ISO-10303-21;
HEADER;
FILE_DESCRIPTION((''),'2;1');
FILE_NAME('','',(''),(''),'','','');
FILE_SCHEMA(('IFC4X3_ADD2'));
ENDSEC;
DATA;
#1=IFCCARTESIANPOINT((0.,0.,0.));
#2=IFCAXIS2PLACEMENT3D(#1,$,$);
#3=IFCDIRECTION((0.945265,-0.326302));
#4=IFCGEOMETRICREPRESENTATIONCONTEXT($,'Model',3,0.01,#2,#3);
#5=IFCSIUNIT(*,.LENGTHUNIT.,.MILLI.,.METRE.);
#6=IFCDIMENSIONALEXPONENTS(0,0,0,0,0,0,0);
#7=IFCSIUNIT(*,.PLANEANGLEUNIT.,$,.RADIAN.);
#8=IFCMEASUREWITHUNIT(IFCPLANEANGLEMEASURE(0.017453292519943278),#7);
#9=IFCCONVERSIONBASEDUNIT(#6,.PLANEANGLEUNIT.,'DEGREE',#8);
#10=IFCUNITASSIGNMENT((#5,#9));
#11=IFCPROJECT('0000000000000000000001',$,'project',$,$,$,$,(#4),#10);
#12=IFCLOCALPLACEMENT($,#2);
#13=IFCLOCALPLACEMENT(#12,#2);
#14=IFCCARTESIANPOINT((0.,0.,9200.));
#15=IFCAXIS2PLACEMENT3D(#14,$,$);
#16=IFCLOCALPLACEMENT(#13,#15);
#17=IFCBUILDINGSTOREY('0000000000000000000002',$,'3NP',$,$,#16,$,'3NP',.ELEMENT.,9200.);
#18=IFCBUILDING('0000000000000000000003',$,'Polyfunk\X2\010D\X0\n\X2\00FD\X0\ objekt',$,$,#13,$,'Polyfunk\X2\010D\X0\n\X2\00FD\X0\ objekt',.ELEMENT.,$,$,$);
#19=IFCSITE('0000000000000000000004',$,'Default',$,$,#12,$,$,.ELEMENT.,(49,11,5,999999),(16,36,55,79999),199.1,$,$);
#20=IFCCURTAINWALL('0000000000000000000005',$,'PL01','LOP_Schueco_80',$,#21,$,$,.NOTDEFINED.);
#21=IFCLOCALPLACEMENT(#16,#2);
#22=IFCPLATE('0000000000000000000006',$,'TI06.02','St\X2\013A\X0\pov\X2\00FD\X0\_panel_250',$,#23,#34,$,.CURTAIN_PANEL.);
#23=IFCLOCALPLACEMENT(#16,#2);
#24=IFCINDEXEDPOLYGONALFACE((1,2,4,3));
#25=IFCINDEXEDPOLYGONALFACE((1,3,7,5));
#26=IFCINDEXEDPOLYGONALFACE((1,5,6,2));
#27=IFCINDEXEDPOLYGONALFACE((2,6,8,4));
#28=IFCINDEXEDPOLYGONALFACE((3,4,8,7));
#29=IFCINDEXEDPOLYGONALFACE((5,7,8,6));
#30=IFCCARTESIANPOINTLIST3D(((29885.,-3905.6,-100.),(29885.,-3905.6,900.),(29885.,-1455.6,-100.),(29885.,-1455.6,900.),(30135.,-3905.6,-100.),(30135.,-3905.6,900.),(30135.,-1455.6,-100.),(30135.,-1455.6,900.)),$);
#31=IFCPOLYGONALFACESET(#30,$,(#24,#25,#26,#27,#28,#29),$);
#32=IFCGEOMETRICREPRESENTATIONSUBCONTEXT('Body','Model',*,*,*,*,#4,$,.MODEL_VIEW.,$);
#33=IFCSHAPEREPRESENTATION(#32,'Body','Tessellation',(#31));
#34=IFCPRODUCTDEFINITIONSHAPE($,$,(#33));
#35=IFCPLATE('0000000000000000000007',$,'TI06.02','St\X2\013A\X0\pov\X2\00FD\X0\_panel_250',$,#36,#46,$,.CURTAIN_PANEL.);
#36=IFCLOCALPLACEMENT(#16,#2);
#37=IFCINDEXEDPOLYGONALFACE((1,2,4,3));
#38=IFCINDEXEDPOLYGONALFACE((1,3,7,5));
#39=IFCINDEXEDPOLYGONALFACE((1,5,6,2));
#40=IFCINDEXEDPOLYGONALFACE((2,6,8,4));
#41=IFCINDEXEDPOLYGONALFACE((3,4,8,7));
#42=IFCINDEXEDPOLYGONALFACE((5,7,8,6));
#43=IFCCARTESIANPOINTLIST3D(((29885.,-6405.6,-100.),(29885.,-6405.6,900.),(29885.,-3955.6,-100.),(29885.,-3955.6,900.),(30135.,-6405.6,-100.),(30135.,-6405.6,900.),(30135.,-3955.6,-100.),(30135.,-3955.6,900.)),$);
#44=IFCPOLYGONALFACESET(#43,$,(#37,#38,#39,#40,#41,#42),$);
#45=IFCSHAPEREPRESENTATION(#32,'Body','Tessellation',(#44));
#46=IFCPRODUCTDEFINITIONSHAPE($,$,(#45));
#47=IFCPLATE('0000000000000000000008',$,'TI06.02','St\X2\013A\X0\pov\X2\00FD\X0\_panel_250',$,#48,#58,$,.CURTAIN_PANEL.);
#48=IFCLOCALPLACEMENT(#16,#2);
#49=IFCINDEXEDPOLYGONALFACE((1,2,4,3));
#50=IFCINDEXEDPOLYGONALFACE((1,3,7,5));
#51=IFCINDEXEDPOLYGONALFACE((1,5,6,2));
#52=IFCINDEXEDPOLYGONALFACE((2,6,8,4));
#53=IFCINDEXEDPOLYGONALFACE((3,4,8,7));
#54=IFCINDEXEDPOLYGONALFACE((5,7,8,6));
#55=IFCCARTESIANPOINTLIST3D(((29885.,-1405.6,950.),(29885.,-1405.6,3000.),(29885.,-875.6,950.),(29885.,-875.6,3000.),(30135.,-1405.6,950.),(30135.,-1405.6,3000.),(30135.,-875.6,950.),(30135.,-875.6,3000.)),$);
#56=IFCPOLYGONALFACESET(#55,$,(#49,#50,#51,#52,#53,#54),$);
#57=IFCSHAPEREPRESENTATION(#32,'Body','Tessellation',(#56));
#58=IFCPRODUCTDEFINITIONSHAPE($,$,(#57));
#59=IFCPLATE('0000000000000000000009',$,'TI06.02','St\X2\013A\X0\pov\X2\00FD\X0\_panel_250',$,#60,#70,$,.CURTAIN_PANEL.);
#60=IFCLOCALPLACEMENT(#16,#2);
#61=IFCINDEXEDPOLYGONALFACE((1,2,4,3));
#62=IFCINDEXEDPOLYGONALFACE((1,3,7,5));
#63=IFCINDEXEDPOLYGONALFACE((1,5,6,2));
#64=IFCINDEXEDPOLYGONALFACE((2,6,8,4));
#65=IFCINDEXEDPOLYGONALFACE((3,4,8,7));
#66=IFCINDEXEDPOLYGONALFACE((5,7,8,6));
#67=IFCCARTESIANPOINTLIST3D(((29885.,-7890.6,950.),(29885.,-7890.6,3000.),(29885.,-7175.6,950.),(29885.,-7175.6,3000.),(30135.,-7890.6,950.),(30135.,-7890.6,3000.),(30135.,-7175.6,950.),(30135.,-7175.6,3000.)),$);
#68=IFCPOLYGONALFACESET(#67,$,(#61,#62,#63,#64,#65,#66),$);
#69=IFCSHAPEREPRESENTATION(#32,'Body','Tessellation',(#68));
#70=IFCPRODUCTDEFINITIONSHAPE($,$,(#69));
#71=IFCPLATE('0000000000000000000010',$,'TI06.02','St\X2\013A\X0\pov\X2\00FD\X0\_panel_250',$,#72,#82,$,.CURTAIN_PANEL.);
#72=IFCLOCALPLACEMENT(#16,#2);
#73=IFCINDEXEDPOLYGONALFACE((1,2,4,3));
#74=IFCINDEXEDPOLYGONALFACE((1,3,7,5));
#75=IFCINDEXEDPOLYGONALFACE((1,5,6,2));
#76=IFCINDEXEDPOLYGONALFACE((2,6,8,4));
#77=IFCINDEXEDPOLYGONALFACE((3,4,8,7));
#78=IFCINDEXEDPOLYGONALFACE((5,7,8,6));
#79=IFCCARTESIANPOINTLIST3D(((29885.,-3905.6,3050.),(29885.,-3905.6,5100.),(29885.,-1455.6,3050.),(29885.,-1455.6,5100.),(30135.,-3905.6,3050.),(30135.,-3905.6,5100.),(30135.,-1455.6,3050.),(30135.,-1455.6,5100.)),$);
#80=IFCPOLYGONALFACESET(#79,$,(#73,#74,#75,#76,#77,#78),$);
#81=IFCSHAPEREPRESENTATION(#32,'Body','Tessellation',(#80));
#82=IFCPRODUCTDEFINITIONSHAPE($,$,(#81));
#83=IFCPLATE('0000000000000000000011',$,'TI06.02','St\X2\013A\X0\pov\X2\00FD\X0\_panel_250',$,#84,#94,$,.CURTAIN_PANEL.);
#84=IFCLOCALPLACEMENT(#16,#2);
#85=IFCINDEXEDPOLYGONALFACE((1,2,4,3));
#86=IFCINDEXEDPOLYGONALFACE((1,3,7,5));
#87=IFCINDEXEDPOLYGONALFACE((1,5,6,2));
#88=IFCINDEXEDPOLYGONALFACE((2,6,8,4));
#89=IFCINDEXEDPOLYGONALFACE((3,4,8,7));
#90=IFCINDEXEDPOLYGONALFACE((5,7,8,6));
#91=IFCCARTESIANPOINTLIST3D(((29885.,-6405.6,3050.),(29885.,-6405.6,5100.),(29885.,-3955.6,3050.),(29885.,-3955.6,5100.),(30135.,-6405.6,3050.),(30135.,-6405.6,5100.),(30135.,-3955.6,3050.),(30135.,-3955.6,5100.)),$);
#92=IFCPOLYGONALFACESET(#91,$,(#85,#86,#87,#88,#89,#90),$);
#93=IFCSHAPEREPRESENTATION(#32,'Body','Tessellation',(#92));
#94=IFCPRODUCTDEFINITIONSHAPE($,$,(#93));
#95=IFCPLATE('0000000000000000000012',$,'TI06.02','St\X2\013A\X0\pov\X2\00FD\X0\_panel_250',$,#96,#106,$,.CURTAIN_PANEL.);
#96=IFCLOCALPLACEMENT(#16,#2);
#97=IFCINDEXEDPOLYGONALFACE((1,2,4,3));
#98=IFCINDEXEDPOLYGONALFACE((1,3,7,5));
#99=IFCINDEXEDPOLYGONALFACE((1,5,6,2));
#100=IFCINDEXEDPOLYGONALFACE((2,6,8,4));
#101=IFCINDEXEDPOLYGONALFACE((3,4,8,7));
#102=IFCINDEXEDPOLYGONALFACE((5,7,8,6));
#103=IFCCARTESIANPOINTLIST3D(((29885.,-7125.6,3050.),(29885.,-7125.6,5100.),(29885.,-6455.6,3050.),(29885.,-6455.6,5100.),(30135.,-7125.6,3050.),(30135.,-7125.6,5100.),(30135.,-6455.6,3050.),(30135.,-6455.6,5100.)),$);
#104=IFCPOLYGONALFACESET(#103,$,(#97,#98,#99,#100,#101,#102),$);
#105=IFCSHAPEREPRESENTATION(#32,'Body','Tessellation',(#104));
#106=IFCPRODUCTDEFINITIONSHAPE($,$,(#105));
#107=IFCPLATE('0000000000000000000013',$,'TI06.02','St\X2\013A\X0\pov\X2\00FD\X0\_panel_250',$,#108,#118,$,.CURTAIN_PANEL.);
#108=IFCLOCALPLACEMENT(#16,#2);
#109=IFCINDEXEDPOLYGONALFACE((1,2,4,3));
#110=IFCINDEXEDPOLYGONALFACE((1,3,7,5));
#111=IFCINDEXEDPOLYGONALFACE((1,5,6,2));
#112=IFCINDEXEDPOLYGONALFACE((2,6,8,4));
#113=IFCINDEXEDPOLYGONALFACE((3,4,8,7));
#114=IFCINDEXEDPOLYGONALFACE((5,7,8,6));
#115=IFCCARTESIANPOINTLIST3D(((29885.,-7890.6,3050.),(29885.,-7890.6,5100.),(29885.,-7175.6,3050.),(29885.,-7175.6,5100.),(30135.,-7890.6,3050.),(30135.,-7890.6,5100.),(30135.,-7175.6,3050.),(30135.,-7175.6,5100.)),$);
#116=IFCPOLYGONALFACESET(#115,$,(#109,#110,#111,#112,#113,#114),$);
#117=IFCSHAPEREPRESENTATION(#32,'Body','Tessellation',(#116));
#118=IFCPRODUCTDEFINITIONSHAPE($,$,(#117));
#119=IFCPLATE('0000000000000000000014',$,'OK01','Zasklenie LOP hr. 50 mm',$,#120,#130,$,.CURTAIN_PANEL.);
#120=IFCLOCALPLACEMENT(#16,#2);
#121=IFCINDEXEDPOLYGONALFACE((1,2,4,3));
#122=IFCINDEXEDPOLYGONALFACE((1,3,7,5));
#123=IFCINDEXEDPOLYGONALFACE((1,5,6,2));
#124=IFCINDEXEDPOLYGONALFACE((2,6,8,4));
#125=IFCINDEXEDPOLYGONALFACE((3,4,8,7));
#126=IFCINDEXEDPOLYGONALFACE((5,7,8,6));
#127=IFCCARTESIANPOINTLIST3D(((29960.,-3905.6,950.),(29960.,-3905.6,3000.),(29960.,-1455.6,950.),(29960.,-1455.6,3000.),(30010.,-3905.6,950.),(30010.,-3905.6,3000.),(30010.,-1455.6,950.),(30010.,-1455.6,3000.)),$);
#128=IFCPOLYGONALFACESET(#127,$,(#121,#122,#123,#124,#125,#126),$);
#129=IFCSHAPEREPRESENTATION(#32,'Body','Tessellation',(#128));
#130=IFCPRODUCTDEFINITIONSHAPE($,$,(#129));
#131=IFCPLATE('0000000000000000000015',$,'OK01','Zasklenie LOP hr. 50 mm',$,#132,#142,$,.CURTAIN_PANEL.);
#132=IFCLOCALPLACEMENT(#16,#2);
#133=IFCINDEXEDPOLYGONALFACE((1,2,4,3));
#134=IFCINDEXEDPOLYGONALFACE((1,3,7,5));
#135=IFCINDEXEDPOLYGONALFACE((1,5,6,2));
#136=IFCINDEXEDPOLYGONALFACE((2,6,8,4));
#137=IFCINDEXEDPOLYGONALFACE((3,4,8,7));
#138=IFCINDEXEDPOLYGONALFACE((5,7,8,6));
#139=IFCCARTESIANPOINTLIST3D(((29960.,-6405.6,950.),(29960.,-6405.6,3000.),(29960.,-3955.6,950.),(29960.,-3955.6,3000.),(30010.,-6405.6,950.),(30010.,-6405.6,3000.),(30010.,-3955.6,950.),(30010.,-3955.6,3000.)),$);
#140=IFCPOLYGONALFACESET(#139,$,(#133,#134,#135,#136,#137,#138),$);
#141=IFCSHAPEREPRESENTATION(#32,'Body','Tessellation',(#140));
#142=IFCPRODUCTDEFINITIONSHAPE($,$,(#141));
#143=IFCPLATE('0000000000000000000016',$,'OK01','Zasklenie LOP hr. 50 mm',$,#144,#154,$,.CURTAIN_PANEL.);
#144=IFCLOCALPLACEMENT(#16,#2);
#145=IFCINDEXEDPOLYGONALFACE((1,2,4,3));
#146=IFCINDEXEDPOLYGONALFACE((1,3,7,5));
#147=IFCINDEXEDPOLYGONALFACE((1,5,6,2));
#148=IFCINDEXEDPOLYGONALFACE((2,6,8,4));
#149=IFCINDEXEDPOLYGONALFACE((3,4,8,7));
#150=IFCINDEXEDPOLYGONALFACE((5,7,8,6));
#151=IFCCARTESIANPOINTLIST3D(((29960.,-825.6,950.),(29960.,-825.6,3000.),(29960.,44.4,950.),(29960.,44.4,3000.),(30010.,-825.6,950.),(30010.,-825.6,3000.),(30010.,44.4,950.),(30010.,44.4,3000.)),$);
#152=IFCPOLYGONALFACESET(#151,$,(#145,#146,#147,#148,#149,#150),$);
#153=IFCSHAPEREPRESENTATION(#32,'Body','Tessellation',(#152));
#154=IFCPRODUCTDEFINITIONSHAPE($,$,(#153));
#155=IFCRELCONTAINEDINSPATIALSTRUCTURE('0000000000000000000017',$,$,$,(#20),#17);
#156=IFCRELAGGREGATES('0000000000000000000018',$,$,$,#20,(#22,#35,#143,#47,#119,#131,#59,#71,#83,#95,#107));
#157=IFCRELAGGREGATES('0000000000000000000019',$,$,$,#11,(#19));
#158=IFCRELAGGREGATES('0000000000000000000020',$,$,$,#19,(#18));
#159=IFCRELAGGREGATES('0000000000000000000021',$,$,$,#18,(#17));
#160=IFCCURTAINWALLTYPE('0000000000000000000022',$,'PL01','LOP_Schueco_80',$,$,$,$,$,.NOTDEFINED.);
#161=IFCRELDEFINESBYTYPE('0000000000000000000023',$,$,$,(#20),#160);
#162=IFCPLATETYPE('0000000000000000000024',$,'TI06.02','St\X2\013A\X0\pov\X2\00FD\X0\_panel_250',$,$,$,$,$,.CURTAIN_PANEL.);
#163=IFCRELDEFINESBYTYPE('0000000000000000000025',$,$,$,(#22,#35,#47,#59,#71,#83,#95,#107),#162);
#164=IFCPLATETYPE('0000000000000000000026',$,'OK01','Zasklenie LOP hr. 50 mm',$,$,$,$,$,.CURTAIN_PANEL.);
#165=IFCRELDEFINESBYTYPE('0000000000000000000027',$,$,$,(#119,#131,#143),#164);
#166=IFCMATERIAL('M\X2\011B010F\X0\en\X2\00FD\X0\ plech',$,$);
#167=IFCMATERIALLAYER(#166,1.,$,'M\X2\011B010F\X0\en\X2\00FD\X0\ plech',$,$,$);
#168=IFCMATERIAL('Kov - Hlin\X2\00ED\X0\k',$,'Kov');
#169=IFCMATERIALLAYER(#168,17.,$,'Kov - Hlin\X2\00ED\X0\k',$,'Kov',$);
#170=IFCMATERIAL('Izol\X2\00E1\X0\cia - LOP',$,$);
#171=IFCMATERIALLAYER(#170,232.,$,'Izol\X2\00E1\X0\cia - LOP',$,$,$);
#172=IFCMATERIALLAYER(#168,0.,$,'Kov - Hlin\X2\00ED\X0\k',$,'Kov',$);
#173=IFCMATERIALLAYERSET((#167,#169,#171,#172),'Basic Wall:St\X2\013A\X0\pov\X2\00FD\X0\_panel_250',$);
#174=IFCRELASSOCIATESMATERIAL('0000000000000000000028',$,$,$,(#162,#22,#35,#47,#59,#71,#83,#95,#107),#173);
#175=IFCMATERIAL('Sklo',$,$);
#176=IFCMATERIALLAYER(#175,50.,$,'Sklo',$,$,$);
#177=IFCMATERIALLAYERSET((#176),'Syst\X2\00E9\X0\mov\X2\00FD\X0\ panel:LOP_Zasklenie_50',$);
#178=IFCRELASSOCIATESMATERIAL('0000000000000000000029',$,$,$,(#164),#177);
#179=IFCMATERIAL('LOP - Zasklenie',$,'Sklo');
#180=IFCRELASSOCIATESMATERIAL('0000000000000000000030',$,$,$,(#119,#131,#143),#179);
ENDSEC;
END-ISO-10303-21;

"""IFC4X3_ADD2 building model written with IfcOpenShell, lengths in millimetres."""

from ifc_helpers import new_model, entity, si_unit, converted_unit, direction, frame, frame_2d, origin, origin_2d_with_axis, place, context, subcontext, project, spatial, rectangle, extrude, source, transform, mapped, material, layer, layer_set, layer_usage, type_object, type_shapes, element, aggregate, save


model = new_model("IFC4X3_ADD2")

# Units and contexts
model_context = context("Model", 3, precision=0.01, world=origin(), true_north=direction((0.945265, -0.326302)))
body_context = subcontext(model_context, "Body", "Model", "MODEL_VIEW")
ifc_project = project(units=[si_unit("LENGTHUNIT", "METRE", prefix="MILLI"), converted_unit("PLANEANGLEUNIT", "DEGREE", entity("IfcPlaneAngleMeasure", 0.017453292519943278), si_unit("PLANEANGLEUNIT", "RADIAN"), dimensions=[0, 0, 0, 0, 0, 0, 0])], contexts=[model_context])

# Site, building, storey
site_placement = place(None, origin())
site = spatial("IfcSite", under=ifc_project, at=site_placement, Name="Default", CompositionType="ELEMENT", RefLatitude=(49, 11, 5, 999999), RefLongitude=(16, 36, 55, 79999), RefElevation=199.1)
building_placement = place(site_placement, origin())
building = spatial("IfcBuilding", under=site, at=building_placement, Name="Polyfunkčný objekt", LongName="Polyfunkčný objekt", CompositionType="ELEMENT")
storey_placement = place(building_placement, frame((0.0, 0.0, 9200.0)))
storey = spatial("IfcBuildingStorey", under=building, at=storey_placement, Name="3NP", LongName="3NP", CompositionType="ELEMENT", Elevation=9200.0)

# Curtain wall, plates
curtain_wall_type = type_object("IfcCurtainWallType", Name="PL01", Description="LOP_Schueco_80", PredefinedType="NOTDEFINED")
curtain_wall_placement = place(storey_placement, frame((0.0, 0.0, -9200.0)))
curtain_wall = element("IfcCurtainWall", 1, at=curtain_wall_placement, inside=storey, type_object=curtain_wall_type, Name="PL01", Description="LOP_Schueco_80", PredefinedType="NOTDEFINED")
ifc_material_1 = material(Name="Měďený plech")
ifc_layer_1 = layer(ifc_material_1, 1.0, Name="Měďený plech")
ifc_material_2 = material(Name="Kov - Hliník", Category="Kov")
ifc_layer_2 = layer(ifc_material_2, 17.0, Name="Kov - Hliník", Category="Kov")
ifc_material_3 = material(Name="Izolácia - LOP")
ifc_layer_3 = layer(ifc_material_3, 232.0, Name="Izolácia - LOP")
ifc_layer_4 = layer(ifc_material_2, 0.0, Name="Kov - Hliník", Category="Kov")
ifc_layer_set_1 = layer_set([ifc_layer_1, ifc_layer_2, ifc_layer_3, ifc_layer_4], Name="Basic Wall:Stĺpový_panel_250")
ifc_layer_usage_1 = layer_usage(ifc_layer_set_1, "AXIS2", "POSITIVE", -125.0)
plate_type_1 = type_object("IfcPlateType", Name="TI06.02", Description="Stĺpový_panel_250", PredefinedType="CURTAIN_PANEL", material=ifc_layer_set_1)
plate_1_placement = place(storey_placement, frame((30010.0, -1455.6, -100.0), z_axis=(0.0, 0.0, 1.0), x_axis=(0.0, -1.0, 0.0)))
plate_1 = element("IfcPlate", 2, at=plate_1_placement, type_object=plate_type_1, material=ifc_layer_usage_1, Name="TI06.02", Description="Stĺpový_panel_250", PredefinedType="CURTAIN_PANEL", context=body_context, shape_type="SweptSolid", body=[
    extrude(rectangle(XDim=250.0, YDim=2450.0, at=origin_2d_with_axis()), frame((1225.0, 0.0, 0.0), z_axis=(0.0, 0.0, 1.0), x_axis=(0.0, 1.0, 0.0)), (0.0, 0.0, 1.0), 1000.0),
])
ifc_layer_usage_2 = layer_usage(ifc_layer_set_1, "AXIS2", "POSITIVE", -125.0)
plate_2_placement = place(storey_placement, frame((30010.0, -3955.6, -100.0), z_axis=(0.0, 0.0, 1.0), x_axis=(0.0, -1.0, 0.0)))
plate_2 = element("IfcPlate", 3, at=plate_2_placement, type_object=plate_type_1, material=ifc_layer_usage_2, Name="TI06.02", Description="Stĺpový_panel_250", PredefinedType="CURTAIN_PANEL", context=body_context, shape_type="SweptSolid", body=[
    extrude(rectangle(XDim=250.0, YDim=2450.0, at=frame_2d((0.0, 0.0), x_axis=(1.0, 0.0))), frame((1225.0, 0.0, 0.0), z_axis=(0.0, 0.0, 1.0), x_axis=(0.0, 1.0, 0.0)), (0.0, 0.0, 1.0), 1000.0),
])
ifc_layer_usage_3 = layer_usage(ifc_layer_set_1, "AXIS2", "POSITIVE", -125.0)
plate_3_placement = place(storey_placement, frame((30010.0, -875.6, 950.0), z_axis=(0.0, 0.0, 1.0), x_axis=(0.0, -1.0, 0.0)))
plate_3 = element("IfcPlate", 4, at=plate_3_placement, type_object=plate_type_1, material=ifc_layer_usage_3, Name="TI06.02", Description="Stĺpový_panel_250", PredefinedType="CURTAIN_PANEL", context=body_context, shape_type="SweptSolid", body=[
    extrude(rectangle(XDim=250.0, YDim=530.0, at=frame_2d((0.0, 0.0), x_axis=(1.0, 0.0))), frame((265.0, 0.0, 0.0), z_axis=(0.0, 0.0, 1.0), x_axis=(0.0, 1.0, 0.0)), (0.0, 0.0, 1.0), 2050.0),
])
ifc_layer_usage_4 = layer_usage(ifc_layer_set_1, "AXIS2", "POSITIVE", -125.0)
plate_4_placement = place(storey_placement, frame((30010.0, -7175.6, 950.0), z_axis=(0.0, 0.0, 1.0), x_axis=(0.0, -1.0, 0.0)))
plate_4 = element("IfcPlate", 5, at=plate_4_placement, type_object=plate_type_1, material=ifc_layer_usage_4, Name="TI06.02", Description="Stĺpový_panel_250", PredefinedType="CURTAIN_PANEL", context=body_context, shape_type="SweptSolid", body=[
    extrude(rectangle(XDim=250.0, YDim=715.0, at=frame_2d((0.0, 0.0), x_axis=(1.0, 0.0))), frame((357.5, 0.0, 0.0), z_axis=(0.0, 0.0, 1.0), x_axis=(0.0, 1.0, 0.0)), (0.0, 0.0, 1.0), 2050.0),
])
ifc_layer_usage_5 = layer_usage(ifc_layer_set_1, "AXIS2", "POSITIVE", -125.0)
plate_5_placement = place(storey_placement, frame((30010.0, -1455.6, 3050.0), z_axis=(0.0, 0.0, 1.0), x_axis=(0.0, -1.0, 0.0)))
plate_5 = element("IfcPlate", 6, at=plate_5_placement, type_object=plate_type_1, material=ifc_layer_usage_5, Name="TI06.02", Description="Stĺpový_panel_250", PredefinedType="CURTAIN_PANEL", context=body_context, shape_type="SweptSolid", body=[
    extrude(rectangle(XDim=250.0, YDim=2450.0, at=origin_2d_with_axis()), frame((1225.0, 0.0, 0.0), z_axis=(0.0, 0.0, 1.0), x_axis=(0.0, 1.0, 0.0)), (0.0, 0.0, 1.0), 2050.0),
])
ifc_layer_usage_6 = layer_usage(ifc_layer_set_1, "AXIS2", "POSITIVE", -125.0)
plate_6_placement = place(storey_placement, frame((30010.0, -3955.6, 3050.0), z_axis=(0.0, 0.0, 1.0), x_axis=(0.0, -1.0, 0.0)))
plate_6 = element("IfcPlate", 7, at=plate_6_placement, type_object=plate_type_1, material=ifc_layer_usage_6, Name="TI06.02", Description="Stĺpový_panel_250", PredefinedType="CURTAIN_PANEL", context=body_context, shape_type="SweptSolid", body=[
    extrude(rectangle(XDim=250.0, YDim=2450.0, at=frame_2d((0.0, 0.0), x_axis=(1.0, 0.0))), frame((1225.0, 0.0, 0.0), z_axis=(0.0, 0.0, 1.0), x_axis=(0.0, 1.0, 0.0)), (0.0, 0.0, 1.0), 2050.0),
])
ifc_layer_usage_7 = layer_usage(ifc_layer_set_1, "AXIS2", "POSITIVE", -125.0)
plate_7_placement = place(storey_placement, frame((30010.0, -6455.6, 3050.0), z_axis=(0.0, 0.0, 1.0), x_axis=(0.0, -1.0, 0.0)))
plate_7 = element("IfcPlate", 8, at=plate_7_placement, type_object=plate_type_1, material=ifc_layer_usage_7, Name="TI06.02", Description="Stĺpový_panel_250", PredefinedType="CURTAIN_PANEL", context=body_context, shape_type="SweptSolid", body=[
    extrude(rectangle(XDim=250.0, YDim=670.0, at=frame_2d((0.0, 0.0), x_axis=(1.0, 0.0))), frame((335.0, 0.0, 0.0), z_axis=(0.0, 0.0, 1.0), x_axis=(0.0, 1.0, 0.0)), (0.0, 0.0, 1.0), 2050.0),
])
ifc_layer_usage_8 = layer_usage(ifc_layer_set_1, "AXIS2", "POSITIVE", -125.0)
plate_8_placement = place(storey_placement, frame((30010.0, -7175.6, 3050.0), z_axis=(0.0, 0.0, 1.0), x_axis=(0.0, -1.0, 0.0)))
plate_8 = element("IfcPlate", 9, at=plate_8_placement, type_object=plate_type_1, material=ifc_layer_usage_8, Name="TI06.02", Description="Stĺpový_panel_250", PredefinedType="CURTAIN_PANEL", context=body_context, shape_type="SweptSolid", body=[
    extrude(rectangle(XDim=250.0, YDim=715.0, at=frame_2d((0.0, 0.0), x_axis=(1.0, 0.0))), frame((357.5, 0.0, 0.0), z_axis=(0.0, 0.0, 1.0), x_axis=(0.0, 1.0, 0.0)), (0.0, 0.0, 1.0), 2050.0),
])
ifc_material_4 = material(Name="LOP - Zasklenie", Category="Sklo")
ifc_material_5 = material(Name="Sklo")
ifc_layer_5 = layer(ifc_material_5, 50.0, Name="Sklo")
ifc_layer_set_2 = layer_set([ifc_layer_5], Name="Systémový panel:LOP_Zasklenie_50")
plate_type_2 = type_object("IfcPlateType", Name="OK01", Description="Zasklenie LOP hr. 50 mm", PredefinedType="CURTAIN_PANEL", material=ifc_layer_set_2)
shared_shape_1 = source(origin(), body_context, "Body", "SweptSolid", [
    extrude(rectangle(XDim=50.0, YDim=2450.0, at=origin_2d_with_axis()), frame((0.0, -25.0, 0.0), z_axis=(0.0, 0.0, 1.0), x_axis=(0.0, 1.0, 0.0)), (0.0, 0.0, 1.0), 2050.0),
])
plate_9_placement = place(curtain_wall_placement, frame((30010.0, -2680.6, 10150.0), z_axis=(0.0, 0.0, 1.0), x_axis=(0.0, -1.0, 0.0)))
plate_9 = element("IfcPlate", 10, at=plate_9_placement, type_object=plate_type_2, material=ifc_material_4, Name="OK01", Description="Zasklenie LOP hr. 50 mm", PredefinedType="CURTAIN_PANEL", context=body_context, shape_type="MappedRepresentation", body=[
    mapped(shared_shape_1, transform((0.0, 0.0, 0.0), scale=1.0)),
])
plate_10_placement = place(curtain_wall_placement, frame((30010.0, -5180.6, 10150.0), z_axis=(0.0, 0.0, 1.0), x_axis=(0.0, -1.0, 0.0)))
plate_10 = element("IfcPlate", 11, at=plate_10_placement, type_object=plate_type_2, material=ifc_material_4, Name="OK01", Description="Zasklenie LOP hr. 50 mm", PredefinedType="CURTAIN_PANEL", context=body_context, shape_type="MappedRepresentation", body=[
    mapped(shared_shape_1, transform((0.0, 0.0, 0.0), scale=1.0)),
])
shared_shape_2 = source(origin(), body_context, "Body", "SweptSolid", [
    extrude(rectangle(XDim=50.0, YDim=870.0, at=origin_2d_with_axis()), frame((0.0, -25.0, 0.0), z_axis=(0.0, 0.0, 1.0), x_axis=(0.0, 1.0, 0.0)), (0.0, 0.0, 1.0), 2050.0),
])
type_shapes(plate_type_2, [shared_shape_1, shared_shape_2])
plate_11_placement = place(curtain_wall_placement, frame((30010.0, -390.6, 10150.0), z_axis=(0.0, 0.0, 1.0), x_axis=(0.0, -1.0, 0.0)))
plate_11 = element("IfcPlate", 12, at=plate_11_placement, type_object=plate_type_2, material=ifc_material_4, Name="OK01", Description="Zasklenie LOP hr. 50 mm", PredefinedType="CURTAIN_PANEL", context=body_context, shape_type="MappedRepresentation", body=[
    mapped(shared_shape_2, transform((0.0, 0.0, 0.0), scale=1.0)),
])
aggregate(curtain_wall, [plate_1, plate_2, plate_11, plate_3, plate_9, plate_10, plate_4, plate_5, plate_6, plate_7, plate_8])

save(model, "model.ifc")
